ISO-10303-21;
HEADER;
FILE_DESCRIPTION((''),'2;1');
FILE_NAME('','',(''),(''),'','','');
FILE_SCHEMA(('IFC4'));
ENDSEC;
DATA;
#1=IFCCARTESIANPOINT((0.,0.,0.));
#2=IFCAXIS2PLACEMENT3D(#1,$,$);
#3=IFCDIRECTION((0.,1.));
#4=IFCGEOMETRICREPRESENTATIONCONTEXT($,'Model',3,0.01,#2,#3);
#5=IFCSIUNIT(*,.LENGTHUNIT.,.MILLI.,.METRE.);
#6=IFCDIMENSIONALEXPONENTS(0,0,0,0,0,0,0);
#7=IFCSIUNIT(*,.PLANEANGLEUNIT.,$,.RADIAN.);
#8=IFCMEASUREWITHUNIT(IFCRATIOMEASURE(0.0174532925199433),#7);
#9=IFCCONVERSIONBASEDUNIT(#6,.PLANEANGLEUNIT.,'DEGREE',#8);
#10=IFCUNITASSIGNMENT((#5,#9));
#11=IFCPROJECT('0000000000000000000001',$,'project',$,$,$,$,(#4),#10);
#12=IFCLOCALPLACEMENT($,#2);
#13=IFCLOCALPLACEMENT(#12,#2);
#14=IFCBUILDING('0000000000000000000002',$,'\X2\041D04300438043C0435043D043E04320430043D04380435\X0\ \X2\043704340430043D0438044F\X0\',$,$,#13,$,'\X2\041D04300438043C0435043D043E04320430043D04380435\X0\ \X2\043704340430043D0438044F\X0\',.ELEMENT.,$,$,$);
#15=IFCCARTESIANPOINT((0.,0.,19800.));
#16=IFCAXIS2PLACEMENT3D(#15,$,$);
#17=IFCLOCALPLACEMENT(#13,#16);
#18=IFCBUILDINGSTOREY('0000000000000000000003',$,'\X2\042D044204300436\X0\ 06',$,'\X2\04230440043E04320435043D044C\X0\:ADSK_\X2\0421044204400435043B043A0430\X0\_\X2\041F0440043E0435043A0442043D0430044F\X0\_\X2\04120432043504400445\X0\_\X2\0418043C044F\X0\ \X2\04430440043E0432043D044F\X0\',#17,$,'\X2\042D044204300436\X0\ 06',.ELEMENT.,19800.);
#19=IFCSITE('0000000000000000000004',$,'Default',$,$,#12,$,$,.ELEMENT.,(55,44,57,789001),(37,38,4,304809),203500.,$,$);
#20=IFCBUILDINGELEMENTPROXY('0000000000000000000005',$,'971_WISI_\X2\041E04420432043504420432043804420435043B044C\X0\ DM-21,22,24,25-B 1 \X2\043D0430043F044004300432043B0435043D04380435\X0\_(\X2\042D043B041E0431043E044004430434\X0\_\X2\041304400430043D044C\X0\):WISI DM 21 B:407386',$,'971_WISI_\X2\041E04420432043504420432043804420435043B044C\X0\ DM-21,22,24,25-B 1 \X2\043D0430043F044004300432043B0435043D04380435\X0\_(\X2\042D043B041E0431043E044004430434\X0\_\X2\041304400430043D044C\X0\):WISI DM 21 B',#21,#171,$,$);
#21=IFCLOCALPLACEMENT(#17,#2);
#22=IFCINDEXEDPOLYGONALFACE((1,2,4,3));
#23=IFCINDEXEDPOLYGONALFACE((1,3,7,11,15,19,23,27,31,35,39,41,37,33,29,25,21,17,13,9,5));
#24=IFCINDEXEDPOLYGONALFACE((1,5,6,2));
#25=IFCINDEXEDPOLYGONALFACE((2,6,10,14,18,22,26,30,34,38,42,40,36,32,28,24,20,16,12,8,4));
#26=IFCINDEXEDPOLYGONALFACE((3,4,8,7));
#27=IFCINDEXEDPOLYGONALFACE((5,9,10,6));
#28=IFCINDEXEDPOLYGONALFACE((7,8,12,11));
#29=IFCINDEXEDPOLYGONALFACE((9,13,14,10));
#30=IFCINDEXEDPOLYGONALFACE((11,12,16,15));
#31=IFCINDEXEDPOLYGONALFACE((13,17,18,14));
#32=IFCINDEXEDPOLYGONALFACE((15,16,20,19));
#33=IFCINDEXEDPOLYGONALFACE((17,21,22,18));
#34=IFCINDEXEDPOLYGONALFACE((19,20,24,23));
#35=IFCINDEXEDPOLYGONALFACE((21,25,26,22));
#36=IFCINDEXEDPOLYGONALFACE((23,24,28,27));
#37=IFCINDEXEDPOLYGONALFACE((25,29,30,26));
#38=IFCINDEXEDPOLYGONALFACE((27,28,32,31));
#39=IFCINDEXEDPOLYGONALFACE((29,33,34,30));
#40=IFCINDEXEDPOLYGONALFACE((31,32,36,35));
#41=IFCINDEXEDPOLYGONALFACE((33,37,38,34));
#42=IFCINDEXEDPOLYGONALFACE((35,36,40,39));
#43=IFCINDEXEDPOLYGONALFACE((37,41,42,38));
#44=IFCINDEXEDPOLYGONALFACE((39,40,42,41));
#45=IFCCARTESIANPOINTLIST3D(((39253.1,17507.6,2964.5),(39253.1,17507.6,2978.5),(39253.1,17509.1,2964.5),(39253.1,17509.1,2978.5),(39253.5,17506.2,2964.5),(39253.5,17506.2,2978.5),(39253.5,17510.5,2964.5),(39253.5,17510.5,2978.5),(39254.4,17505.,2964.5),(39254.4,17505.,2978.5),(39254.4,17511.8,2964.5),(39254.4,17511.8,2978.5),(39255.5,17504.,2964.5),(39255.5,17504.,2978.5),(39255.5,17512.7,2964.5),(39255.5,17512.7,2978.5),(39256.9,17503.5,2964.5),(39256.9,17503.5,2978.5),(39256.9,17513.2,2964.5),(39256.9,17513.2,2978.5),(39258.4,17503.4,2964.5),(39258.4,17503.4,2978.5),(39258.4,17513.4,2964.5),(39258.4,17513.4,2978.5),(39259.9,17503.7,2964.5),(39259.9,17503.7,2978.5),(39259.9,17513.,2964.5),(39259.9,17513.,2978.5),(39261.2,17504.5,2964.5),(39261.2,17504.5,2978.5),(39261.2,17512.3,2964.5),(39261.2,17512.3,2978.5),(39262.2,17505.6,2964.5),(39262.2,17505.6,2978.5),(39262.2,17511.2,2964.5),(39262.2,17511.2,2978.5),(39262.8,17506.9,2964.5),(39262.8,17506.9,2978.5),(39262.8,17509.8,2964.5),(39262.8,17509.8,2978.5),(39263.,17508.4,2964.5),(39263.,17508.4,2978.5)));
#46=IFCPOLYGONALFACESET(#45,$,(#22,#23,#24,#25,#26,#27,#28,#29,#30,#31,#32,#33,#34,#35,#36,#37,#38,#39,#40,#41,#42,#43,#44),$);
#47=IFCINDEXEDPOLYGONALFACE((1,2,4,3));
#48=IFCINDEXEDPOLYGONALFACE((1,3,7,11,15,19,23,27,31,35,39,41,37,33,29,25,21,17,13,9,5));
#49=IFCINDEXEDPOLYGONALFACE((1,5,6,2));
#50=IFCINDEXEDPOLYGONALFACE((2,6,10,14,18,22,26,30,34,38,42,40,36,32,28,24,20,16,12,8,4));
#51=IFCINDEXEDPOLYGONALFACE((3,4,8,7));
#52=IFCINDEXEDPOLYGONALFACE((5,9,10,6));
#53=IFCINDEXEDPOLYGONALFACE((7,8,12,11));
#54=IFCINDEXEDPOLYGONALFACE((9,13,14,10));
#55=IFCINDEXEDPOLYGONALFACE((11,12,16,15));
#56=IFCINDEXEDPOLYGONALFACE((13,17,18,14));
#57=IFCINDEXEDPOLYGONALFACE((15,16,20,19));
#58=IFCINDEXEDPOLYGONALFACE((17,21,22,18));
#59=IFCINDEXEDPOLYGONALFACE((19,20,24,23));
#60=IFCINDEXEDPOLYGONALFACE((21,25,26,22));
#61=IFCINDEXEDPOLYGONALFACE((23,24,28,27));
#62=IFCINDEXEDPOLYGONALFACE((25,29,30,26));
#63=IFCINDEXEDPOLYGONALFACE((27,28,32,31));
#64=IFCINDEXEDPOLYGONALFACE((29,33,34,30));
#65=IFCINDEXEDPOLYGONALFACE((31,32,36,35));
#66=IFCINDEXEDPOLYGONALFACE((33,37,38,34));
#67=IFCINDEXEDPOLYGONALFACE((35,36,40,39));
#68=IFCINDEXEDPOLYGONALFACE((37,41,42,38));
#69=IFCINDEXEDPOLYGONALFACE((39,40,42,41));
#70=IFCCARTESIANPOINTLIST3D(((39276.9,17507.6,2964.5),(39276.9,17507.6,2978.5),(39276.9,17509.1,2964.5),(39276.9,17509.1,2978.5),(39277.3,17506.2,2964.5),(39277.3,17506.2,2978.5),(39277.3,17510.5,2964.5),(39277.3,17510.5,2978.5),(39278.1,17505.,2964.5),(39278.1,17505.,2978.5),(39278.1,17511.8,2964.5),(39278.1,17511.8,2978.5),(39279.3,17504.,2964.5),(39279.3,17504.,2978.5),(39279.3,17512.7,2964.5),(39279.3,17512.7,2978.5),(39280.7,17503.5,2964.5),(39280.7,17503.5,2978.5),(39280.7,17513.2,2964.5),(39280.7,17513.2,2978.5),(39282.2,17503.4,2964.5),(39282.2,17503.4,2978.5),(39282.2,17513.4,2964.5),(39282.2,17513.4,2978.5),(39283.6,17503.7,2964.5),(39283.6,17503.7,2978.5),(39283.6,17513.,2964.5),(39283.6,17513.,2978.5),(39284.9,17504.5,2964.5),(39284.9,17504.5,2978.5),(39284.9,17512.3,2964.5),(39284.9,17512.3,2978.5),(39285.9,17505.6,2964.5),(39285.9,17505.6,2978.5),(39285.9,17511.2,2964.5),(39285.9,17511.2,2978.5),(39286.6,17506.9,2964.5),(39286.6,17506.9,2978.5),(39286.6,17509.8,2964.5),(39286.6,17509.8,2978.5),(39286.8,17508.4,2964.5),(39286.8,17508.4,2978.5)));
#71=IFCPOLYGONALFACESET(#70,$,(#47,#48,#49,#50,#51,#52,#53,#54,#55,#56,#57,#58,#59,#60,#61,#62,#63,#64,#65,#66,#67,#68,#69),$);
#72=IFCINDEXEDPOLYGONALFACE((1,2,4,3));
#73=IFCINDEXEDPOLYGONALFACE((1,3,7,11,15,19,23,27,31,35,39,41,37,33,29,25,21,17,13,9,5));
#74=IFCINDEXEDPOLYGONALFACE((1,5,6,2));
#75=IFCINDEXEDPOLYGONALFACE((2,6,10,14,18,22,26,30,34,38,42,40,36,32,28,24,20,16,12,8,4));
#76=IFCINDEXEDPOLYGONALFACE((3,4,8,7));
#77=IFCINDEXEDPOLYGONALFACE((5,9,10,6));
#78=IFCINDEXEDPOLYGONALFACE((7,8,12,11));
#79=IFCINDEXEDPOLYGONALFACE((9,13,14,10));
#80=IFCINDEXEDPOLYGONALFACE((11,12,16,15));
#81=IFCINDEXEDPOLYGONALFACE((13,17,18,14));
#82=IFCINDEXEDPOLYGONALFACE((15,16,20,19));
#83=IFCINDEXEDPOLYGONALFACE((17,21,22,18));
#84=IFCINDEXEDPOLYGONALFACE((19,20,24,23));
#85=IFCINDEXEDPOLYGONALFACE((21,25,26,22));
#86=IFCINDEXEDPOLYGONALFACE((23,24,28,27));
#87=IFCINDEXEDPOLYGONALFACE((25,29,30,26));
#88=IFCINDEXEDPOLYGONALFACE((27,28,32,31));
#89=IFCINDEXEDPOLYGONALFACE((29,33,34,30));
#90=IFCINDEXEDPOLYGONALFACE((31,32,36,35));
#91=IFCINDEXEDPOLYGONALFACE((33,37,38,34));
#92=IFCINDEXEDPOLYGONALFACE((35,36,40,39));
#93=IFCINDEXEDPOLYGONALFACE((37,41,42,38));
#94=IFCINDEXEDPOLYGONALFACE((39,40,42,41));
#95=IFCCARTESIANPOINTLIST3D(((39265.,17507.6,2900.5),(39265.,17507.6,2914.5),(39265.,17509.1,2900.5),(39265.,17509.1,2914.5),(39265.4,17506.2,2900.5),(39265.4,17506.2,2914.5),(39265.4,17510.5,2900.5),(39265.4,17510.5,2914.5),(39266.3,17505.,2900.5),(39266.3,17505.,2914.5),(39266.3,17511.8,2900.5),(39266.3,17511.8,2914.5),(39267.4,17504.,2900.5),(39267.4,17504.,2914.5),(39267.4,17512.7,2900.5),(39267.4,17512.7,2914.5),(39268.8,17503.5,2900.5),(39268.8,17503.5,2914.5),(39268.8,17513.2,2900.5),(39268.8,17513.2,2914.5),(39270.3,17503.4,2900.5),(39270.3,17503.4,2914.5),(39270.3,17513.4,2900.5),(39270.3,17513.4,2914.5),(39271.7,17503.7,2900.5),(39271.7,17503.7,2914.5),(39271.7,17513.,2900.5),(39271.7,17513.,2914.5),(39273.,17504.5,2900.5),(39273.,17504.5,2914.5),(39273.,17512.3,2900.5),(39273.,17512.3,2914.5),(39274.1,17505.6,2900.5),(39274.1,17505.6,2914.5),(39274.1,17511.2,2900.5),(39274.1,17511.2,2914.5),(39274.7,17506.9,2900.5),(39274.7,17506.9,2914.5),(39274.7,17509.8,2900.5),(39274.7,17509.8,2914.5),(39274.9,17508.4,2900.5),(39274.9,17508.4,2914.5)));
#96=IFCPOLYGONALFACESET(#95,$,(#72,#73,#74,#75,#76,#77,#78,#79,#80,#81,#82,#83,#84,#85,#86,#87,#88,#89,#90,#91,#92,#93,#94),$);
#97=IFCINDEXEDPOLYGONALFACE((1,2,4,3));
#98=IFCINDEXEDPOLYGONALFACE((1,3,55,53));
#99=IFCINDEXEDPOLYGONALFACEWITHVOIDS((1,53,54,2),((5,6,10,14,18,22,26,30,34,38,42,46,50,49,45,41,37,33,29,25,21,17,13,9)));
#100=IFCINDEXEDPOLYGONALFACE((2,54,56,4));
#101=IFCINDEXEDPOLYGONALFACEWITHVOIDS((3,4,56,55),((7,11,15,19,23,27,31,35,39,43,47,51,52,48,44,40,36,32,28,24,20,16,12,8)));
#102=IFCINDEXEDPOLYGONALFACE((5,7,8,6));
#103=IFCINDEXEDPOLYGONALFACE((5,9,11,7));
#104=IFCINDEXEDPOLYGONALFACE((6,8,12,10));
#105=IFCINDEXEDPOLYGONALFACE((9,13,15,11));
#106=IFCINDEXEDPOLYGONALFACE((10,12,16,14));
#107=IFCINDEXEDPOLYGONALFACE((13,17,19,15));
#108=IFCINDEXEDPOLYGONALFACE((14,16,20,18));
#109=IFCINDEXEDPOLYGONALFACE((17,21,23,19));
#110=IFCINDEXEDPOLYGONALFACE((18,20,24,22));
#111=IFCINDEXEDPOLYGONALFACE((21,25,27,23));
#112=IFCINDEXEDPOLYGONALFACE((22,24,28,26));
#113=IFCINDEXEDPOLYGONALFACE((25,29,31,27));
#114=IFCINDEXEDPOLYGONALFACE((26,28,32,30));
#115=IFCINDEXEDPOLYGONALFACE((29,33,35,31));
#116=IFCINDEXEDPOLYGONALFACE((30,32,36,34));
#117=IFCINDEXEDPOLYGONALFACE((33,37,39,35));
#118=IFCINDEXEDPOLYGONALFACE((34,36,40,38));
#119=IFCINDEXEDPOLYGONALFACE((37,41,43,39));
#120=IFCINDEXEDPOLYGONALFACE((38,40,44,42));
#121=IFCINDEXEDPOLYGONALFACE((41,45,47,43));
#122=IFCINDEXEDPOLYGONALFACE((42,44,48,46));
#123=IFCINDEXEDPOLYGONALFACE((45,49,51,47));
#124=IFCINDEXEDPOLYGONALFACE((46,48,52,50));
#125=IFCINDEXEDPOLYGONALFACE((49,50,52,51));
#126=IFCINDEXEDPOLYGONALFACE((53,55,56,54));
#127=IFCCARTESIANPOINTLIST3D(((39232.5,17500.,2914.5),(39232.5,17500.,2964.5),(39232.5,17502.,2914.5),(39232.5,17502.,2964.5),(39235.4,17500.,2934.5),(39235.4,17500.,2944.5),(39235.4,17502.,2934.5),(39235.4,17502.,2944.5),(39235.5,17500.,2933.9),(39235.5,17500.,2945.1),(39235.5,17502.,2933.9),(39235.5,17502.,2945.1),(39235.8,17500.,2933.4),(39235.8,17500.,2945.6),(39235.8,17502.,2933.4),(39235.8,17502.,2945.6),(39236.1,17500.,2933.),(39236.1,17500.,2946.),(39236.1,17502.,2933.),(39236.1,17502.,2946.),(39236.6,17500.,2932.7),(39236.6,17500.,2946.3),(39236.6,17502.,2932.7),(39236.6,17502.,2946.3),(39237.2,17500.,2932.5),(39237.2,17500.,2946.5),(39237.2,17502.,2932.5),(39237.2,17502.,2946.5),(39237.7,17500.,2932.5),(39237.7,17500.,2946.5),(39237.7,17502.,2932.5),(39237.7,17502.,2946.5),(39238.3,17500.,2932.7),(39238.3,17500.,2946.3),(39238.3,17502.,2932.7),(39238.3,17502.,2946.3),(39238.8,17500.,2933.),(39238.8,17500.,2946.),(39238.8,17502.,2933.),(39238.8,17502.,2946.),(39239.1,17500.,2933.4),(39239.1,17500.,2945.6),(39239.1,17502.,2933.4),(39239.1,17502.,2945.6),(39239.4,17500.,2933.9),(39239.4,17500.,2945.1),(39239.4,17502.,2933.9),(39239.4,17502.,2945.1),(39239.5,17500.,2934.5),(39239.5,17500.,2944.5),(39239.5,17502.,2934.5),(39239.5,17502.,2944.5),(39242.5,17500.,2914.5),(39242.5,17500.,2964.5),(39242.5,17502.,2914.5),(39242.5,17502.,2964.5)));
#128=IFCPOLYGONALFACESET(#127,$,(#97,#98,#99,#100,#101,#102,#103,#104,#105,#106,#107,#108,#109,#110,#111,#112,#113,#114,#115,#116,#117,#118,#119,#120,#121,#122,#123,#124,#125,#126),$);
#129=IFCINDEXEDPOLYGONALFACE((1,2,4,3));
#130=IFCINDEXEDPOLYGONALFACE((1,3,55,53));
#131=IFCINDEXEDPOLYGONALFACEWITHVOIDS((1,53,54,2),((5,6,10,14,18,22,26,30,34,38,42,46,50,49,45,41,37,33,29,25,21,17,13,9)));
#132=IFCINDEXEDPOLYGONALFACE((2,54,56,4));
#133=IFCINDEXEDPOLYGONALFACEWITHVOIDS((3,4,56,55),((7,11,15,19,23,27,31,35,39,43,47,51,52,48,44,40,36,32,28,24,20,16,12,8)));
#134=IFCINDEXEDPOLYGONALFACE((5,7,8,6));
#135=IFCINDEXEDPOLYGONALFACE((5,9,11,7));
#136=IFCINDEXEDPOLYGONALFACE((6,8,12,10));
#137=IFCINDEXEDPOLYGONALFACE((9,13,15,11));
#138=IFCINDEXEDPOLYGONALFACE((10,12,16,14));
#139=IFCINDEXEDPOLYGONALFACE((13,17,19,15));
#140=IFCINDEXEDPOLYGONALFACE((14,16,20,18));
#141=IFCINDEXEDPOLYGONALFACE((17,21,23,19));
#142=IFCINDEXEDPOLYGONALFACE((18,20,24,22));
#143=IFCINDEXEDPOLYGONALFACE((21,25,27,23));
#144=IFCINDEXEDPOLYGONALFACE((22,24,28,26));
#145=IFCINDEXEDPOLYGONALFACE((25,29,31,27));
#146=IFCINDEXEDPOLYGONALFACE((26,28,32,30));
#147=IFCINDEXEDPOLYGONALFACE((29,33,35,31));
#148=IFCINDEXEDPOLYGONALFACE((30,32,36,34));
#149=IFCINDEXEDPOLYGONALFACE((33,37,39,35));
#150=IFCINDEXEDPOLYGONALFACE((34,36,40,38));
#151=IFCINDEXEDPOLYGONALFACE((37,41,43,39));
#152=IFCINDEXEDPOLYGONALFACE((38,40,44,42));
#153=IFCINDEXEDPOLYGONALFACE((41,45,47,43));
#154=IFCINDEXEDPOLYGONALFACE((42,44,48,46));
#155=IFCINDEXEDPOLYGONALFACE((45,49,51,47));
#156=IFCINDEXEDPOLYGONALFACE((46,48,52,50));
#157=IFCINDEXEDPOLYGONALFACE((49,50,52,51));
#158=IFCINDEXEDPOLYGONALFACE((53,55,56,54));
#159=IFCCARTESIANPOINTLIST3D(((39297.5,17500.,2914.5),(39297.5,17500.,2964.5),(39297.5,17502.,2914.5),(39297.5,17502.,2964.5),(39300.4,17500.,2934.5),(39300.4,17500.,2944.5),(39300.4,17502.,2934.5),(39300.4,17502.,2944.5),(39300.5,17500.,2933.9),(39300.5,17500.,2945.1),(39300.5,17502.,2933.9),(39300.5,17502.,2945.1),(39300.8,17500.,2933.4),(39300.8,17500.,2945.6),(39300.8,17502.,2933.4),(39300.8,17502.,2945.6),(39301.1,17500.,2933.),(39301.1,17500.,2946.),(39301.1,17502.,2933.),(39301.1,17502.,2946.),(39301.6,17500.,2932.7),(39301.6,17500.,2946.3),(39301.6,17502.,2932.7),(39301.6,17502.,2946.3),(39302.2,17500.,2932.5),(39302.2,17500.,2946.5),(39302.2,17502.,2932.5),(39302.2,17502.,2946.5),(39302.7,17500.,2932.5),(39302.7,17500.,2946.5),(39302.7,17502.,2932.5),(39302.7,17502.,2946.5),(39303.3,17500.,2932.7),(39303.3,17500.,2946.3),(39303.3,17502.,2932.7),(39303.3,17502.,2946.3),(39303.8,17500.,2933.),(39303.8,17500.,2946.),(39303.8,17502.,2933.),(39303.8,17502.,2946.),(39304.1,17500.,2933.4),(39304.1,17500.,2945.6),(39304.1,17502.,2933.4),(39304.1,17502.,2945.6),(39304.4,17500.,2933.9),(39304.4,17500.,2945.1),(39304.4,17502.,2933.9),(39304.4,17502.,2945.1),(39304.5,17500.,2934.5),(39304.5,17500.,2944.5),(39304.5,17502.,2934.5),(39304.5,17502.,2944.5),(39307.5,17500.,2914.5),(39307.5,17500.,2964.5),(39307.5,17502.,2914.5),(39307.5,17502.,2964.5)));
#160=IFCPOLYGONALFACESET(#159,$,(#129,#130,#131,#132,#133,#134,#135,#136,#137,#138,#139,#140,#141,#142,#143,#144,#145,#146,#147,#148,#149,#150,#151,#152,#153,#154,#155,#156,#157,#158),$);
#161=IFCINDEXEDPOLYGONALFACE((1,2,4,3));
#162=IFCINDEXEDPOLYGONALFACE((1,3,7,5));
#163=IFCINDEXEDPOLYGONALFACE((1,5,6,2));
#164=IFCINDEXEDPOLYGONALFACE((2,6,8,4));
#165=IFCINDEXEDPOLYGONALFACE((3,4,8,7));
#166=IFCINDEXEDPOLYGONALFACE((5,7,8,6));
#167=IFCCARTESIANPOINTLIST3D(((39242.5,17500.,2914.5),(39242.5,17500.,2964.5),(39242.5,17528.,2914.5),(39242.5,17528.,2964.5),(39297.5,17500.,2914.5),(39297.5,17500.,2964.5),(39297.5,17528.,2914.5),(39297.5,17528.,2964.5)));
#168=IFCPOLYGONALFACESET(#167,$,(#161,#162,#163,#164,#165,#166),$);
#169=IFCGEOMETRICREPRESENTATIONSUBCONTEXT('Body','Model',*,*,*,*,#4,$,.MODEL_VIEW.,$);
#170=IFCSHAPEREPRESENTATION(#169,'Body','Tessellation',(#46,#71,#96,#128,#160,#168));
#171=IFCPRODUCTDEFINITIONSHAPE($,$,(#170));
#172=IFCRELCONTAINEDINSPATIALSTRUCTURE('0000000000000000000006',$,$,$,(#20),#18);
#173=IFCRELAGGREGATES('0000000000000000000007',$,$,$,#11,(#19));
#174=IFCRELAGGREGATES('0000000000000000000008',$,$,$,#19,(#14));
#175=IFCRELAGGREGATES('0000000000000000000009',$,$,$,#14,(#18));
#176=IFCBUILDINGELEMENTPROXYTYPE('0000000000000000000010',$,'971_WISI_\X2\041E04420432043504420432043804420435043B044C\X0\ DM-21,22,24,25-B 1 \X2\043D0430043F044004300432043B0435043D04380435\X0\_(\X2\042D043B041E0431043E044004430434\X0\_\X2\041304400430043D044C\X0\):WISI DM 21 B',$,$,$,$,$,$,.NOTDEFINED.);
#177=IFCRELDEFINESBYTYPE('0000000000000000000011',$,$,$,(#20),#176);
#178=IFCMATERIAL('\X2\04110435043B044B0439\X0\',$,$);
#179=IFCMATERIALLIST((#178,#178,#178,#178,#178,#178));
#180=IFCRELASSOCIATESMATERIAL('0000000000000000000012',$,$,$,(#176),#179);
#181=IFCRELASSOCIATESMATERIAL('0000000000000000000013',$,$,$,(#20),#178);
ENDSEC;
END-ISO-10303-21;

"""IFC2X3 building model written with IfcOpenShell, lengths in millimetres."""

from ifc_helpers import new_model, entity, si_unit, converted_unit, direction, frame, frame_2d, origin, place, context, subcontext, project, spatial, polyline, circle_curve, parameter, trimmed, segment, composite_curve, rectangle, circle, outline, extrude, source, transform, mapped, material, material_list, type_object, type_shapes, element, save


model = new_model("IFC2X3")

# Units and contexts
model_context = context("Model", 3, precision=0.01, world=origin(), true_north=direction((0.0, 1.0)))
body_context = subcontext(model_context, "Body", "Model", "MODEL_VIEW")
ifc_project = project(units=[si_unit("LENGTHUNIT", "METRE", prefix="MILLI"), converted_unit("PLANEANGLEUNIT", "DEGREE", entity("IfcRatioMeasure", 0.0174532925199433), si_unit("PLANEANGLEUNIT", "RADIAN"), dimensions=[0, 0, 0, 0, 0, 0, 0])], contexts=[model_context])

# Site, building, storey
site_placement = place(None, frame((0.0, 0.0, 0.0)))
site = spatial("IfcSite", under=ifc_project, at=site_placement, Name="Default", CompositionType="ELEMENT", RefLatitude=(55, 44, 57, 789001), RefLongitude=(37, 38, 4, 304809), RefElevation=203500.0)
building_placement = place(site_placement, origin())
building = spatial("IfcBuilding", under=site, at=building_placement, Name="Наименование здания", LongName="Наименование здания", CompositionType="ELEMENT")
storey_placement = place(building_placement, frame((0.0, 0.0, 19800.0)))
storey = spatial("IfcBuildingStorey", under=building, at=storey_placement, Name="Этаж 06", ObjectType="Уровень:ADSK_Стрелка_Проектная_Вверх_Имя уровня", LongName="Этаж 06", CompositionType="ELEMENT", Elevation=19800.0)

# Building element proxy
ifc_material_1 = material(Name="Белый")
ifc_material_list_1 = material_list([ifc_material_1, ifc_material_1, ifc_material_1, ifc_material_1, ifc_material_1, ifc_material_1])
building_element_proxy_type_1 = type_object("IfcBuildingElementProxyType", Name="971_WISI_Ответвитель DM-21,22,24,25-B 1 направление_(ЭлОборуд_Грань):WISI DM 21 B", PredefinedType="NOTDEFINED", material=ifc_material_list_1)
shared_shape_1 = source(origin(), body_context, "Body", "SweptSolid", [
    extrude(circle(Radius=5.0, at=frame_2d((0.0, 0.0), x_axis=(1.0, 0.0))), frame((11.9, 25.0, 8.4), z_axis=(0.0, 1.0, 0.0), x_axis=(-1.0, 0.0, 0.0)), (0.0, 0.0, 1.0), 14.0),
    extrude(circle(Radius=5.0, at=frame_2d((0.0, 0.0), x_axis=(1.0, 0.0))), frame((-11.8, 25.0, 8.4), z_axis=(0.0, 1.0, 0.0), x_axis=(-1.0, 0.0, 0.0)), (0.0, 0.0, 1.0), 14.0),
    extrude(circle(Radius=5.0, at=frame_2d((0.0, 0.0), x_axis=(1.0, 0.0))), frame((0.0, -39.0, 8.4), z_axis=(0.0, 1.0, 0.0), x_axis=(-1.0, 0.0, 0.0)), (0.0, 0.0, 1.0), 14.0),
    extrude(outline(polyline([(-5.0, -25.0), (5.0, -25.0), (5.0, 25.0), (-5.0, 25.0), (-5.0, -25.0)]), holes=[composite_curve([segment(polyline([(2.0, 5.0), (2.0, -5.0)]), True, "CONTINUOUS"), segment(trimmed(circle_curve(frame_2d((0.0, -5.0), x_axis=(-1.0, 0.0)), 2.0), [parameter(0.0)], [parameter(180.0)], True, "PARAMETER"), False, "CONTINUOUS"), segment(polyline([(-2.0, -5.0), (-2.0, 5.0)]), True, "CONTINUOUS"), segment(trimmed(circle_curve(frame_2d((0.0, 5.0), x_axis=(-1.0, 0.0)), 2.0), [parameter(180.0)], [parameter(0.0)], True, "PARAMETER"), False, "CONTINUOUS")], self_intersect=False)]), frame((32.5, 0.0, 0.0), z_axis=(0.0, 0.0, 1.0), x_axis=(-1.0, 0.0, 0.0)), (0.0, 0.0, 1.0), 2.0),
    extrude(outline(polyline([(-5.0, -25.0), (5.0, -25.0), (5.0, 25.0), (-5.0, 25.0), (-5.0, -25.0)]), holes=[composite_curve([segment(polyline([(-2.0, -5.0), (-2.0, 5.0)]), True, "CONTINUOUS"), segment(trimmed(circle_curve(frame_2d((0.0, 5.0), x_axis=(-1.0, 0.0)), 2.0), [parameter(180.0)], [parameter(0.0)], True, "PARAMETER"), False, "CONTINUOUS"), segment(polyline([(2.0, 5.0), (2.0, -5.0)]), True, "CONTINUOUS"), segment(trimmed(circle_curve(frame_2d((0.0, -5.0), x_axis=(-1.0, 0.0)), 2.0), [parameter(0.0)], [parameter(180.0)], True, "PARAMETER"), False, "CONTINUOUS")], self_intersect=False)]), frame((-32.5, 0.0, 0.0), z_axis=(0.0, 0.0, 1.0), x_axis=(-1.0, 0.0, 0.0)), (0.0, 0.0, 1.0), 2.0),
    extrude(rectangle(XDim=55.0, YDim=50.0, at=frame_2d((0.0, 0.0), x_axis=(1.0, 0.0))), frame((0.0, 0.0, 0.0), z_axis=(0.0, 0.0, 1.0), x_axis=(-1.0, 0.0, 0.0)), (0.0, 0.0, 1.0), 28.0),
])
type_shapes(building_element_proxy_type_1, [shared_shape_1])
for number, where, z_axis, x_axis, name in (
    (1, (39270.0, 17500.0, 2939.5), (0.0, 1.0, 0.0), (-1.0, 0.0, 0.0), "971_WISI_Ответвитель DM-21,22,24,25-B 1 направление_(ЭлОборуд_Грань):WISI DM 21 B:407386"),
):
    element("IfcBuildingElementProxy", number, at=place(storey_placement, frame(where, z_axis=z_axis, x_axis=x_axis)), inside=storey, type_object=building_element_proxy_type_1, material=ifc_material_1, Name=name, ObjectType="971_WISI_Ответвитель DM-21,22,24,25-B 1 направление_(ЭлОборуд_Грань):WISI DM 21 B", context=body_context, shape_type="MappedRepresentation", body=[
        mapped(shared_shape_1, transform((0.0, 0.0, 0.0), scale=1.0)),
    ])

save(model, "model.ifc")
